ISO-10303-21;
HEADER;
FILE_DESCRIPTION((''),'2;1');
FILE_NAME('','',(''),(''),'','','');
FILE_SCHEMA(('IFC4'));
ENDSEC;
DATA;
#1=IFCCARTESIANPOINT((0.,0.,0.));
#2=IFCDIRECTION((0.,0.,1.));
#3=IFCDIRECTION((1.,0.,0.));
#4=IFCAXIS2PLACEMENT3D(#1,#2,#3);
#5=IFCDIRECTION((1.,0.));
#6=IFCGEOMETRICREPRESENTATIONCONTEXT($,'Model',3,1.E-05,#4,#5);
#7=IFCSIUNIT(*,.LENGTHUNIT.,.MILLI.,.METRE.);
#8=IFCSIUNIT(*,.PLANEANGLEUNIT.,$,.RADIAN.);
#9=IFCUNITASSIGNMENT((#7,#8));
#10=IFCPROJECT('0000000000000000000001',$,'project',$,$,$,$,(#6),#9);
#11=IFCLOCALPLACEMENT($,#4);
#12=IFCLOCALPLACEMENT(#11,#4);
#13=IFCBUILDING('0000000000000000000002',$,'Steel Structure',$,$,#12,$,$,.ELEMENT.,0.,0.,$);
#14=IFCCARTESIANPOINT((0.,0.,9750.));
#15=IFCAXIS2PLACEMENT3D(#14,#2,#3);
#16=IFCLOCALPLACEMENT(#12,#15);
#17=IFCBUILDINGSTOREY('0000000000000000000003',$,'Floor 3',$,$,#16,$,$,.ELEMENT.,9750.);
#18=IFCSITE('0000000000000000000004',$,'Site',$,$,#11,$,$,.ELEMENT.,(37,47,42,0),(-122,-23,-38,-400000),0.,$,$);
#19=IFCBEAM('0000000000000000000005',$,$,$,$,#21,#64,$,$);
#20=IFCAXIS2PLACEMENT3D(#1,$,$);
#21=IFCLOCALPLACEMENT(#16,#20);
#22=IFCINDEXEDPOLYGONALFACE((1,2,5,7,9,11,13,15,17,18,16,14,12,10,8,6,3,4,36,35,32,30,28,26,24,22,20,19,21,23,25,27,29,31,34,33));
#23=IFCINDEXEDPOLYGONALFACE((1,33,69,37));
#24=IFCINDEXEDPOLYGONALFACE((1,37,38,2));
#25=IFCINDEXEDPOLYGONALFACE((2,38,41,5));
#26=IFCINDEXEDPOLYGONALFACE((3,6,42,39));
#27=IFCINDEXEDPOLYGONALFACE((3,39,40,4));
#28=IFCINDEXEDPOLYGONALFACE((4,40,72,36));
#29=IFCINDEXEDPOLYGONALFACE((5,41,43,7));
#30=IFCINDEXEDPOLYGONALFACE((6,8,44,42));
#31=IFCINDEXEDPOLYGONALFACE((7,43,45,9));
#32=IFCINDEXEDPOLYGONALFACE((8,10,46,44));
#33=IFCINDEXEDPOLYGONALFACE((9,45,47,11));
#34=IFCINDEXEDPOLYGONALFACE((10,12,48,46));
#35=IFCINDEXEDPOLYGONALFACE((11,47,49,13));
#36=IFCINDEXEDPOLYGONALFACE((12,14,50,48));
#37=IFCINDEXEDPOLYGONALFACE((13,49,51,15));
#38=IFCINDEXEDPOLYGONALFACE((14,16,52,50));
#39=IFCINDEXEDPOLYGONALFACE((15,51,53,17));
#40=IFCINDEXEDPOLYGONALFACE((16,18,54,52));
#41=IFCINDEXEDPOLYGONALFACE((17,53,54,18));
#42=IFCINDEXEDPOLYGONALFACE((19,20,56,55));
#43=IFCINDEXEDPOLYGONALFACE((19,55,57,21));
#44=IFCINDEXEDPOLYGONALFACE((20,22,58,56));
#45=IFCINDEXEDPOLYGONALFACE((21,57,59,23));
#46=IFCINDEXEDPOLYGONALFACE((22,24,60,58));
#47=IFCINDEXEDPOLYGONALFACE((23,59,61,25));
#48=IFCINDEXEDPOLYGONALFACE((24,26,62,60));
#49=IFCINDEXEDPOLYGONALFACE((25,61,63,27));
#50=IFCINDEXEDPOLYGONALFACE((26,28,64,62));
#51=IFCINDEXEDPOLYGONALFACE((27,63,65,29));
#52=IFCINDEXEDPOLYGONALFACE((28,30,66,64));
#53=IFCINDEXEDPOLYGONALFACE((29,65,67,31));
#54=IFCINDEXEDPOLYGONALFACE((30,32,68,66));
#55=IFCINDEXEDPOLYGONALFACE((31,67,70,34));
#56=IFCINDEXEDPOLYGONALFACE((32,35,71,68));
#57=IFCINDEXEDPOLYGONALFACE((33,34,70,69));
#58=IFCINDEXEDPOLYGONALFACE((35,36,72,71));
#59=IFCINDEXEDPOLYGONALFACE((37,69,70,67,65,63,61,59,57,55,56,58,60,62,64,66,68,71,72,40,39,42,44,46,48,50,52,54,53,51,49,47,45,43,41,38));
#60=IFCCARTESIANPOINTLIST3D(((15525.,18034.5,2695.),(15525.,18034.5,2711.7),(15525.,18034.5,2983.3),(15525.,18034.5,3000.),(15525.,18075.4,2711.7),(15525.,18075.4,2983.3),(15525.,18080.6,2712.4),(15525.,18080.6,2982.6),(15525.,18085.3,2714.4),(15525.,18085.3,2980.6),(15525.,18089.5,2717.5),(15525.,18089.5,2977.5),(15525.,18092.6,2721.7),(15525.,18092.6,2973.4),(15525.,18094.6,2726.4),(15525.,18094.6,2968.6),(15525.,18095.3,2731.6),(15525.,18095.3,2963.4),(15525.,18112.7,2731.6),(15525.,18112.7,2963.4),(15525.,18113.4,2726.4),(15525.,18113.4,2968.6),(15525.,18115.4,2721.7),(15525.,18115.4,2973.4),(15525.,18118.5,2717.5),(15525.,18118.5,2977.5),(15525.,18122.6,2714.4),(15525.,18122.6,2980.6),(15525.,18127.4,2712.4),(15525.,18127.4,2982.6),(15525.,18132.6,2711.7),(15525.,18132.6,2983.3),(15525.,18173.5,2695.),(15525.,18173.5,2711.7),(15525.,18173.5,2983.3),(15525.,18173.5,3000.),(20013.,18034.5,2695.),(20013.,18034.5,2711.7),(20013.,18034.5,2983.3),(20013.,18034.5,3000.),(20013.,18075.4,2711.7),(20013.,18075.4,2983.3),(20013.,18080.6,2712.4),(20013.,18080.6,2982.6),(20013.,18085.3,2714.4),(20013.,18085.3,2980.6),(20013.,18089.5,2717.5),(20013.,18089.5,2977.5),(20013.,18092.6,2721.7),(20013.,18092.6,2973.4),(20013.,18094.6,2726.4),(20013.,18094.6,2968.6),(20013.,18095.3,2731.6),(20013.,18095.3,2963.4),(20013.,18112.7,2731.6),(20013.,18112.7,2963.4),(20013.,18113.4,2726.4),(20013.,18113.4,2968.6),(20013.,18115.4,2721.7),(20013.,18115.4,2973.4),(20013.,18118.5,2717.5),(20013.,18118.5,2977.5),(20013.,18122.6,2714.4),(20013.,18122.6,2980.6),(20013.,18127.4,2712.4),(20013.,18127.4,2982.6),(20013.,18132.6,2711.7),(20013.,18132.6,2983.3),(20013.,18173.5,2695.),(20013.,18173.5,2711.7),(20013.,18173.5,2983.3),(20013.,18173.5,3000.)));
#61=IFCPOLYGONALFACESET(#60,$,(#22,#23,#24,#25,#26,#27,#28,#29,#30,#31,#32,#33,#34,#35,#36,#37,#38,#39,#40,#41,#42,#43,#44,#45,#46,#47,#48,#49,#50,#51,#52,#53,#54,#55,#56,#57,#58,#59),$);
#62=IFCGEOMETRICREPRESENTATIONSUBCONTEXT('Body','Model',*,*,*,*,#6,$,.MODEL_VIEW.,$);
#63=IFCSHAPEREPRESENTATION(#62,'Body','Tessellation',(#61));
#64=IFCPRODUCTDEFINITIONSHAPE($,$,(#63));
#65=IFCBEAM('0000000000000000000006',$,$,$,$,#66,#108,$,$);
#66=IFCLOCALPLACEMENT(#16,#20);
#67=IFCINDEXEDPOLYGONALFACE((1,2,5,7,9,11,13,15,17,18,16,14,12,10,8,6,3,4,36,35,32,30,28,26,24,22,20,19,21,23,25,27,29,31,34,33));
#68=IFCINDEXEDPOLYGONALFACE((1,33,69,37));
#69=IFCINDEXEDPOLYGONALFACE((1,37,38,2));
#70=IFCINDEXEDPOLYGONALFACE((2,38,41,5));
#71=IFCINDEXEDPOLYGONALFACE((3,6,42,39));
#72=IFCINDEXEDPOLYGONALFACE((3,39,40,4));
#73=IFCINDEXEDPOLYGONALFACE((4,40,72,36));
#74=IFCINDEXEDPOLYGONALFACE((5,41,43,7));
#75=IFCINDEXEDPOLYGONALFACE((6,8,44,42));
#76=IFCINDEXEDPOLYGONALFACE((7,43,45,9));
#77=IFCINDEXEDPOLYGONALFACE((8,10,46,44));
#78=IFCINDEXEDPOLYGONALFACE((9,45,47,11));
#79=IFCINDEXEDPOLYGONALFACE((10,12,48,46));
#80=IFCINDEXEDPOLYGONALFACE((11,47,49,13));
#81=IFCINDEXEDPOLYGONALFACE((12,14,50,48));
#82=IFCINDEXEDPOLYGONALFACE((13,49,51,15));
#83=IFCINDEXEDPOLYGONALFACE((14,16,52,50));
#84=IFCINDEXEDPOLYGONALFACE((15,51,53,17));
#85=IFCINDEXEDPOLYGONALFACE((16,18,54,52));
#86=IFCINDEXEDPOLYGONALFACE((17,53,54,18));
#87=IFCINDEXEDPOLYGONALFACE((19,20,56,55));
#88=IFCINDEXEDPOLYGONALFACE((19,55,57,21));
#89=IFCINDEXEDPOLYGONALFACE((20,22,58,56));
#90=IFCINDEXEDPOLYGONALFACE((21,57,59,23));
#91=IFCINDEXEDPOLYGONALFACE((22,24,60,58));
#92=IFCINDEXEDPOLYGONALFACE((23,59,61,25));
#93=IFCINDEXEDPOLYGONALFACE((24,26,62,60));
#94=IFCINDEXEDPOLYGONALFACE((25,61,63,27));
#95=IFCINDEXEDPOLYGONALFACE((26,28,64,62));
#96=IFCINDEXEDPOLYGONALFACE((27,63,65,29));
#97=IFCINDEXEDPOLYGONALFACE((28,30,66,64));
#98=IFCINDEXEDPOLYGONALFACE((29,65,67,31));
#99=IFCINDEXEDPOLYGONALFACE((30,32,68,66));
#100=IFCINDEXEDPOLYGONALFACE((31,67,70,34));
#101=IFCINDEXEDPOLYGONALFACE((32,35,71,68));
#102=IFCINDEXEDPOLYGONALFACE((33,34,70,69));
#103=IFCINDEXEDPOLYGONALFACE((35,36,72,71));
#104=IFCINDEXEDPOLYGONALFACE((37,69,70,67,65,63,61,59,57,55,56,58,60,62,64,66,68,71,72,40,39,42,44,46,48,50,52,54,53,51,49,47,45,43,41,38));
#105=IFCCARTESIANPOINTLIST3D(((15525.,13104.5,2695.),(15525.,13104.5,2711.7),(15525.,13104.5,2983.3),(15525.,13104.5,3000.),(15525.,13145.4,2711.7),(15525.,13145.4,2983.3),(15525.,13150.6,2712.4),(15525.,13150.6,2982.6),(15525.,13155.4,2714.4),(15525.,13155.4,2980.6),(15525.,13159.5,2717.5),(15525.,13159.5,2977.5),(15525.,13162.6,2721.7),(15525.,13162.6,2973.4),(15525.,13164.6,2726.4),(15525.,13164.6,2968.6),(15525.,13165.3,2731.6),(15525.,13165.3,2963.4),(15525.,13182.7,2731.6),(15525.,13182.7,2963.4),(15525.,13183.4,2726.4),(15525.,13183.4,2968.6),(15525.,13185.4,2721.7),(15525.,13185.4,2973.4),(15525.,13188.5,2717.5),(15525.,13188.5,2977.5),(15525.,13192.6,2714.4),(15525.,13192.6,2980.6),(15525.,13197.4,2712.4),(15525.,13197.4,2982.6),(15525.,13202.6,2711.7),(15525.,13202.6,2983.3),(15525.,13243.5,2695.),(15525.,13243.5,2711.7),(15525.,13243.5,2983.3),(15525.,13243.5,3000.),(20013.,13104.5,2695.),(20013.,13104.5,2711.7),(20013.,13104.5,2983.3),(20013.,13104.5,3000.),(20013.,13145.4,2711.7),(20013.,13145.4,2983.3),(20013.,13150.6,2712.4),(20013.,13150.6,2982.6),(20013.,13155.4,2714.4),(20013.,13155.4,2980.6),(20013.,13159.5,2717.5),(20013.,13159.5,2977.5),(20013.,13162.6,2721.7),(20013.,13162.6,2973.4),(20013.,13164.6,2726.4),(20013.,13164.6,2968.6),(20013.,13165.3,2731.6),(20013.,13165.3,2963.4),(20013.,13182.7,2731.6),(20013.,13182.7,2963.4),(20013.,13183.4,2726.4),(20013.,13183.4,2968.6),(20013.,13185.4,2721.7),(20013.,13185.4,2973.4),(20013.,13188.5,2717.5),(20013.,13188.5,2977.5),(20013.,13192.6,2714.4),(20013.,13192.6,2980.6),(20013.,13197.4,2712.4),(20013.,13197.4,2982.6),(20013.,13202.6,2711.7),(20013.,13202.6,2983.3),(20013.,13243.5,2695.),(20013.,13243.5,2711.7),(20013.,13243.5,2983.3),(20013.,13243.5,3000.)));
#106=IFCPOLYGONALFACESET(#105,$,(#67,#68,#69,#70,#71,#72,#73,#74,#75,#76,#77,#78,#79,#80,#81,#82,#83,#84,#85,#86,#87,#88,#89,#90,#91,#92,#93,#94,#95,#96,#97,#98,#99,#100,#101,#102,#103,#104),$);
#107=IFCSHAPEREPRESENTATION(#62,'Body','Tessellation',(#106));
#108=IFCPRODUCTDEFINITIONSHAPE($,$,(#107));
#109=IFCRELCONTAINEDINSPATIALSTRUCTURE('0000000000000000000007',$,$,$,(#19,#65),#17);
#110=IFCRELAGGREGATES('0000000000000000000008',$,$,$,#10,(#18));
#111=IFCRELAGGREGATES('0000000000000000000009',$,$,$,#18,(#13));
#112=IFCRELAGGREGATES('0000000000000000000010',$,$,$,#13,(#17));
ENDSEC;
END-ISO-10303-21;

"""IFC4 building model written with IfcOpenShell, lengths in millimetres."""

from ifc_helpers import new_model, si_unit, direction, frame, origin_with_axes, origin_2d_with_axis, place, context, subcontext, project, spatial, i_section, extrude, element, save


model = new_model("IFC4")

# Units and contexts
model_context = context("Model", 3, precision=1e-05, world=origin_with_axes(), true_north=direction((1.0, 0.0)))
body_context = subcontext(model_context, "Body", "Model", "MODEL_VIEW")
ifc_project = project(units=[si_unit("LENGTHUNIT", "METRE", prefix="MILLI"), si_unit("PLANEANGLEUNIT", "RADIAN")], contexts=[model_context])

# Site, building, storey
site_placement = place(None, origin_with_axes())
site = spatial("IfcSite", under=ifc_project, at=site_placement, Name="Site", CompositionType="ELEMENT", RefLatitude=(37, 47, 42, 0), RefLongitude=(-122, -23, -38, -400000), RefElevation=0.0)
building_placement = place(site_placement, origin_with_axes())
building = spatial("IfcBuilding", under=site, at=building_placement, Name="Steel Structure", CompositionType="ELEMENT", ElevationOfRefHeight=0.0, ElevationOfTerrain=0.0)
storey_placement = place(building_placement, frame((0.0, 0.0, 9750.0), z_axis=(0.0, 0.0, 1.0), x_axis=(1.0, 0.0, 0.0)))
storey = spatial("IfcBuildingStorey", under=building, at=storey_placement, Name="Floor 3", CompositionType="ELEMENT", Elevation=9750.0)

# Beams
beam_1_placement = place(storey_placement, frame((20013.0, 18104.0, 2695.0), z_axis=(-1.0, 0.0, 0.0), x_axis=(0.0, -1.0, 0.0)))
element("IfcBeam", 1, at=beam_1_placement, inside=storey, context=body_context, shape_type="SweptSolid", body=[
    extrude(i_section(OverallWidth=139.0, OverallDepth=305.0, WebThickness=17.4, FlangeThickness=16.7, FilletRadius=19.9, at=origin_2d_with_axis()), frame((0.0, 152.5, 0.0), z_axis=(0.0, 0.0, 1.0), x_axis=(1.0, 0.0, 0.0)), (0.0, 0.0, 1.0), 4488.0),
])
beam_2_placement = place(storey_placement, frame((15525.0, 13174.0, 2695.0), z_axis=(1.0, 0.0, 0.0), x_axis=(0.0, 1.0, 0.0)))
element("IfcBeam", 2, at=beam_2_placement, inside=storey, context=body_context, shape_type="SweptSolid", body=[
    extrude(i_section(OverallWidth=139.0, OverallDepth=305.0, WebThickness=17.4, FlangeThickness=16.7, FilletRadius=19.9, at=origin_2d_with_axis()), frame((0.0, 152.5, 0.0), z_axis=(0.0, 0.0, 1.0), x_axis=(1.0, 0.0, 0.0)), (0.0, 0.0, 1.0), 4488.0),
])

save(model, "model.ifc")
